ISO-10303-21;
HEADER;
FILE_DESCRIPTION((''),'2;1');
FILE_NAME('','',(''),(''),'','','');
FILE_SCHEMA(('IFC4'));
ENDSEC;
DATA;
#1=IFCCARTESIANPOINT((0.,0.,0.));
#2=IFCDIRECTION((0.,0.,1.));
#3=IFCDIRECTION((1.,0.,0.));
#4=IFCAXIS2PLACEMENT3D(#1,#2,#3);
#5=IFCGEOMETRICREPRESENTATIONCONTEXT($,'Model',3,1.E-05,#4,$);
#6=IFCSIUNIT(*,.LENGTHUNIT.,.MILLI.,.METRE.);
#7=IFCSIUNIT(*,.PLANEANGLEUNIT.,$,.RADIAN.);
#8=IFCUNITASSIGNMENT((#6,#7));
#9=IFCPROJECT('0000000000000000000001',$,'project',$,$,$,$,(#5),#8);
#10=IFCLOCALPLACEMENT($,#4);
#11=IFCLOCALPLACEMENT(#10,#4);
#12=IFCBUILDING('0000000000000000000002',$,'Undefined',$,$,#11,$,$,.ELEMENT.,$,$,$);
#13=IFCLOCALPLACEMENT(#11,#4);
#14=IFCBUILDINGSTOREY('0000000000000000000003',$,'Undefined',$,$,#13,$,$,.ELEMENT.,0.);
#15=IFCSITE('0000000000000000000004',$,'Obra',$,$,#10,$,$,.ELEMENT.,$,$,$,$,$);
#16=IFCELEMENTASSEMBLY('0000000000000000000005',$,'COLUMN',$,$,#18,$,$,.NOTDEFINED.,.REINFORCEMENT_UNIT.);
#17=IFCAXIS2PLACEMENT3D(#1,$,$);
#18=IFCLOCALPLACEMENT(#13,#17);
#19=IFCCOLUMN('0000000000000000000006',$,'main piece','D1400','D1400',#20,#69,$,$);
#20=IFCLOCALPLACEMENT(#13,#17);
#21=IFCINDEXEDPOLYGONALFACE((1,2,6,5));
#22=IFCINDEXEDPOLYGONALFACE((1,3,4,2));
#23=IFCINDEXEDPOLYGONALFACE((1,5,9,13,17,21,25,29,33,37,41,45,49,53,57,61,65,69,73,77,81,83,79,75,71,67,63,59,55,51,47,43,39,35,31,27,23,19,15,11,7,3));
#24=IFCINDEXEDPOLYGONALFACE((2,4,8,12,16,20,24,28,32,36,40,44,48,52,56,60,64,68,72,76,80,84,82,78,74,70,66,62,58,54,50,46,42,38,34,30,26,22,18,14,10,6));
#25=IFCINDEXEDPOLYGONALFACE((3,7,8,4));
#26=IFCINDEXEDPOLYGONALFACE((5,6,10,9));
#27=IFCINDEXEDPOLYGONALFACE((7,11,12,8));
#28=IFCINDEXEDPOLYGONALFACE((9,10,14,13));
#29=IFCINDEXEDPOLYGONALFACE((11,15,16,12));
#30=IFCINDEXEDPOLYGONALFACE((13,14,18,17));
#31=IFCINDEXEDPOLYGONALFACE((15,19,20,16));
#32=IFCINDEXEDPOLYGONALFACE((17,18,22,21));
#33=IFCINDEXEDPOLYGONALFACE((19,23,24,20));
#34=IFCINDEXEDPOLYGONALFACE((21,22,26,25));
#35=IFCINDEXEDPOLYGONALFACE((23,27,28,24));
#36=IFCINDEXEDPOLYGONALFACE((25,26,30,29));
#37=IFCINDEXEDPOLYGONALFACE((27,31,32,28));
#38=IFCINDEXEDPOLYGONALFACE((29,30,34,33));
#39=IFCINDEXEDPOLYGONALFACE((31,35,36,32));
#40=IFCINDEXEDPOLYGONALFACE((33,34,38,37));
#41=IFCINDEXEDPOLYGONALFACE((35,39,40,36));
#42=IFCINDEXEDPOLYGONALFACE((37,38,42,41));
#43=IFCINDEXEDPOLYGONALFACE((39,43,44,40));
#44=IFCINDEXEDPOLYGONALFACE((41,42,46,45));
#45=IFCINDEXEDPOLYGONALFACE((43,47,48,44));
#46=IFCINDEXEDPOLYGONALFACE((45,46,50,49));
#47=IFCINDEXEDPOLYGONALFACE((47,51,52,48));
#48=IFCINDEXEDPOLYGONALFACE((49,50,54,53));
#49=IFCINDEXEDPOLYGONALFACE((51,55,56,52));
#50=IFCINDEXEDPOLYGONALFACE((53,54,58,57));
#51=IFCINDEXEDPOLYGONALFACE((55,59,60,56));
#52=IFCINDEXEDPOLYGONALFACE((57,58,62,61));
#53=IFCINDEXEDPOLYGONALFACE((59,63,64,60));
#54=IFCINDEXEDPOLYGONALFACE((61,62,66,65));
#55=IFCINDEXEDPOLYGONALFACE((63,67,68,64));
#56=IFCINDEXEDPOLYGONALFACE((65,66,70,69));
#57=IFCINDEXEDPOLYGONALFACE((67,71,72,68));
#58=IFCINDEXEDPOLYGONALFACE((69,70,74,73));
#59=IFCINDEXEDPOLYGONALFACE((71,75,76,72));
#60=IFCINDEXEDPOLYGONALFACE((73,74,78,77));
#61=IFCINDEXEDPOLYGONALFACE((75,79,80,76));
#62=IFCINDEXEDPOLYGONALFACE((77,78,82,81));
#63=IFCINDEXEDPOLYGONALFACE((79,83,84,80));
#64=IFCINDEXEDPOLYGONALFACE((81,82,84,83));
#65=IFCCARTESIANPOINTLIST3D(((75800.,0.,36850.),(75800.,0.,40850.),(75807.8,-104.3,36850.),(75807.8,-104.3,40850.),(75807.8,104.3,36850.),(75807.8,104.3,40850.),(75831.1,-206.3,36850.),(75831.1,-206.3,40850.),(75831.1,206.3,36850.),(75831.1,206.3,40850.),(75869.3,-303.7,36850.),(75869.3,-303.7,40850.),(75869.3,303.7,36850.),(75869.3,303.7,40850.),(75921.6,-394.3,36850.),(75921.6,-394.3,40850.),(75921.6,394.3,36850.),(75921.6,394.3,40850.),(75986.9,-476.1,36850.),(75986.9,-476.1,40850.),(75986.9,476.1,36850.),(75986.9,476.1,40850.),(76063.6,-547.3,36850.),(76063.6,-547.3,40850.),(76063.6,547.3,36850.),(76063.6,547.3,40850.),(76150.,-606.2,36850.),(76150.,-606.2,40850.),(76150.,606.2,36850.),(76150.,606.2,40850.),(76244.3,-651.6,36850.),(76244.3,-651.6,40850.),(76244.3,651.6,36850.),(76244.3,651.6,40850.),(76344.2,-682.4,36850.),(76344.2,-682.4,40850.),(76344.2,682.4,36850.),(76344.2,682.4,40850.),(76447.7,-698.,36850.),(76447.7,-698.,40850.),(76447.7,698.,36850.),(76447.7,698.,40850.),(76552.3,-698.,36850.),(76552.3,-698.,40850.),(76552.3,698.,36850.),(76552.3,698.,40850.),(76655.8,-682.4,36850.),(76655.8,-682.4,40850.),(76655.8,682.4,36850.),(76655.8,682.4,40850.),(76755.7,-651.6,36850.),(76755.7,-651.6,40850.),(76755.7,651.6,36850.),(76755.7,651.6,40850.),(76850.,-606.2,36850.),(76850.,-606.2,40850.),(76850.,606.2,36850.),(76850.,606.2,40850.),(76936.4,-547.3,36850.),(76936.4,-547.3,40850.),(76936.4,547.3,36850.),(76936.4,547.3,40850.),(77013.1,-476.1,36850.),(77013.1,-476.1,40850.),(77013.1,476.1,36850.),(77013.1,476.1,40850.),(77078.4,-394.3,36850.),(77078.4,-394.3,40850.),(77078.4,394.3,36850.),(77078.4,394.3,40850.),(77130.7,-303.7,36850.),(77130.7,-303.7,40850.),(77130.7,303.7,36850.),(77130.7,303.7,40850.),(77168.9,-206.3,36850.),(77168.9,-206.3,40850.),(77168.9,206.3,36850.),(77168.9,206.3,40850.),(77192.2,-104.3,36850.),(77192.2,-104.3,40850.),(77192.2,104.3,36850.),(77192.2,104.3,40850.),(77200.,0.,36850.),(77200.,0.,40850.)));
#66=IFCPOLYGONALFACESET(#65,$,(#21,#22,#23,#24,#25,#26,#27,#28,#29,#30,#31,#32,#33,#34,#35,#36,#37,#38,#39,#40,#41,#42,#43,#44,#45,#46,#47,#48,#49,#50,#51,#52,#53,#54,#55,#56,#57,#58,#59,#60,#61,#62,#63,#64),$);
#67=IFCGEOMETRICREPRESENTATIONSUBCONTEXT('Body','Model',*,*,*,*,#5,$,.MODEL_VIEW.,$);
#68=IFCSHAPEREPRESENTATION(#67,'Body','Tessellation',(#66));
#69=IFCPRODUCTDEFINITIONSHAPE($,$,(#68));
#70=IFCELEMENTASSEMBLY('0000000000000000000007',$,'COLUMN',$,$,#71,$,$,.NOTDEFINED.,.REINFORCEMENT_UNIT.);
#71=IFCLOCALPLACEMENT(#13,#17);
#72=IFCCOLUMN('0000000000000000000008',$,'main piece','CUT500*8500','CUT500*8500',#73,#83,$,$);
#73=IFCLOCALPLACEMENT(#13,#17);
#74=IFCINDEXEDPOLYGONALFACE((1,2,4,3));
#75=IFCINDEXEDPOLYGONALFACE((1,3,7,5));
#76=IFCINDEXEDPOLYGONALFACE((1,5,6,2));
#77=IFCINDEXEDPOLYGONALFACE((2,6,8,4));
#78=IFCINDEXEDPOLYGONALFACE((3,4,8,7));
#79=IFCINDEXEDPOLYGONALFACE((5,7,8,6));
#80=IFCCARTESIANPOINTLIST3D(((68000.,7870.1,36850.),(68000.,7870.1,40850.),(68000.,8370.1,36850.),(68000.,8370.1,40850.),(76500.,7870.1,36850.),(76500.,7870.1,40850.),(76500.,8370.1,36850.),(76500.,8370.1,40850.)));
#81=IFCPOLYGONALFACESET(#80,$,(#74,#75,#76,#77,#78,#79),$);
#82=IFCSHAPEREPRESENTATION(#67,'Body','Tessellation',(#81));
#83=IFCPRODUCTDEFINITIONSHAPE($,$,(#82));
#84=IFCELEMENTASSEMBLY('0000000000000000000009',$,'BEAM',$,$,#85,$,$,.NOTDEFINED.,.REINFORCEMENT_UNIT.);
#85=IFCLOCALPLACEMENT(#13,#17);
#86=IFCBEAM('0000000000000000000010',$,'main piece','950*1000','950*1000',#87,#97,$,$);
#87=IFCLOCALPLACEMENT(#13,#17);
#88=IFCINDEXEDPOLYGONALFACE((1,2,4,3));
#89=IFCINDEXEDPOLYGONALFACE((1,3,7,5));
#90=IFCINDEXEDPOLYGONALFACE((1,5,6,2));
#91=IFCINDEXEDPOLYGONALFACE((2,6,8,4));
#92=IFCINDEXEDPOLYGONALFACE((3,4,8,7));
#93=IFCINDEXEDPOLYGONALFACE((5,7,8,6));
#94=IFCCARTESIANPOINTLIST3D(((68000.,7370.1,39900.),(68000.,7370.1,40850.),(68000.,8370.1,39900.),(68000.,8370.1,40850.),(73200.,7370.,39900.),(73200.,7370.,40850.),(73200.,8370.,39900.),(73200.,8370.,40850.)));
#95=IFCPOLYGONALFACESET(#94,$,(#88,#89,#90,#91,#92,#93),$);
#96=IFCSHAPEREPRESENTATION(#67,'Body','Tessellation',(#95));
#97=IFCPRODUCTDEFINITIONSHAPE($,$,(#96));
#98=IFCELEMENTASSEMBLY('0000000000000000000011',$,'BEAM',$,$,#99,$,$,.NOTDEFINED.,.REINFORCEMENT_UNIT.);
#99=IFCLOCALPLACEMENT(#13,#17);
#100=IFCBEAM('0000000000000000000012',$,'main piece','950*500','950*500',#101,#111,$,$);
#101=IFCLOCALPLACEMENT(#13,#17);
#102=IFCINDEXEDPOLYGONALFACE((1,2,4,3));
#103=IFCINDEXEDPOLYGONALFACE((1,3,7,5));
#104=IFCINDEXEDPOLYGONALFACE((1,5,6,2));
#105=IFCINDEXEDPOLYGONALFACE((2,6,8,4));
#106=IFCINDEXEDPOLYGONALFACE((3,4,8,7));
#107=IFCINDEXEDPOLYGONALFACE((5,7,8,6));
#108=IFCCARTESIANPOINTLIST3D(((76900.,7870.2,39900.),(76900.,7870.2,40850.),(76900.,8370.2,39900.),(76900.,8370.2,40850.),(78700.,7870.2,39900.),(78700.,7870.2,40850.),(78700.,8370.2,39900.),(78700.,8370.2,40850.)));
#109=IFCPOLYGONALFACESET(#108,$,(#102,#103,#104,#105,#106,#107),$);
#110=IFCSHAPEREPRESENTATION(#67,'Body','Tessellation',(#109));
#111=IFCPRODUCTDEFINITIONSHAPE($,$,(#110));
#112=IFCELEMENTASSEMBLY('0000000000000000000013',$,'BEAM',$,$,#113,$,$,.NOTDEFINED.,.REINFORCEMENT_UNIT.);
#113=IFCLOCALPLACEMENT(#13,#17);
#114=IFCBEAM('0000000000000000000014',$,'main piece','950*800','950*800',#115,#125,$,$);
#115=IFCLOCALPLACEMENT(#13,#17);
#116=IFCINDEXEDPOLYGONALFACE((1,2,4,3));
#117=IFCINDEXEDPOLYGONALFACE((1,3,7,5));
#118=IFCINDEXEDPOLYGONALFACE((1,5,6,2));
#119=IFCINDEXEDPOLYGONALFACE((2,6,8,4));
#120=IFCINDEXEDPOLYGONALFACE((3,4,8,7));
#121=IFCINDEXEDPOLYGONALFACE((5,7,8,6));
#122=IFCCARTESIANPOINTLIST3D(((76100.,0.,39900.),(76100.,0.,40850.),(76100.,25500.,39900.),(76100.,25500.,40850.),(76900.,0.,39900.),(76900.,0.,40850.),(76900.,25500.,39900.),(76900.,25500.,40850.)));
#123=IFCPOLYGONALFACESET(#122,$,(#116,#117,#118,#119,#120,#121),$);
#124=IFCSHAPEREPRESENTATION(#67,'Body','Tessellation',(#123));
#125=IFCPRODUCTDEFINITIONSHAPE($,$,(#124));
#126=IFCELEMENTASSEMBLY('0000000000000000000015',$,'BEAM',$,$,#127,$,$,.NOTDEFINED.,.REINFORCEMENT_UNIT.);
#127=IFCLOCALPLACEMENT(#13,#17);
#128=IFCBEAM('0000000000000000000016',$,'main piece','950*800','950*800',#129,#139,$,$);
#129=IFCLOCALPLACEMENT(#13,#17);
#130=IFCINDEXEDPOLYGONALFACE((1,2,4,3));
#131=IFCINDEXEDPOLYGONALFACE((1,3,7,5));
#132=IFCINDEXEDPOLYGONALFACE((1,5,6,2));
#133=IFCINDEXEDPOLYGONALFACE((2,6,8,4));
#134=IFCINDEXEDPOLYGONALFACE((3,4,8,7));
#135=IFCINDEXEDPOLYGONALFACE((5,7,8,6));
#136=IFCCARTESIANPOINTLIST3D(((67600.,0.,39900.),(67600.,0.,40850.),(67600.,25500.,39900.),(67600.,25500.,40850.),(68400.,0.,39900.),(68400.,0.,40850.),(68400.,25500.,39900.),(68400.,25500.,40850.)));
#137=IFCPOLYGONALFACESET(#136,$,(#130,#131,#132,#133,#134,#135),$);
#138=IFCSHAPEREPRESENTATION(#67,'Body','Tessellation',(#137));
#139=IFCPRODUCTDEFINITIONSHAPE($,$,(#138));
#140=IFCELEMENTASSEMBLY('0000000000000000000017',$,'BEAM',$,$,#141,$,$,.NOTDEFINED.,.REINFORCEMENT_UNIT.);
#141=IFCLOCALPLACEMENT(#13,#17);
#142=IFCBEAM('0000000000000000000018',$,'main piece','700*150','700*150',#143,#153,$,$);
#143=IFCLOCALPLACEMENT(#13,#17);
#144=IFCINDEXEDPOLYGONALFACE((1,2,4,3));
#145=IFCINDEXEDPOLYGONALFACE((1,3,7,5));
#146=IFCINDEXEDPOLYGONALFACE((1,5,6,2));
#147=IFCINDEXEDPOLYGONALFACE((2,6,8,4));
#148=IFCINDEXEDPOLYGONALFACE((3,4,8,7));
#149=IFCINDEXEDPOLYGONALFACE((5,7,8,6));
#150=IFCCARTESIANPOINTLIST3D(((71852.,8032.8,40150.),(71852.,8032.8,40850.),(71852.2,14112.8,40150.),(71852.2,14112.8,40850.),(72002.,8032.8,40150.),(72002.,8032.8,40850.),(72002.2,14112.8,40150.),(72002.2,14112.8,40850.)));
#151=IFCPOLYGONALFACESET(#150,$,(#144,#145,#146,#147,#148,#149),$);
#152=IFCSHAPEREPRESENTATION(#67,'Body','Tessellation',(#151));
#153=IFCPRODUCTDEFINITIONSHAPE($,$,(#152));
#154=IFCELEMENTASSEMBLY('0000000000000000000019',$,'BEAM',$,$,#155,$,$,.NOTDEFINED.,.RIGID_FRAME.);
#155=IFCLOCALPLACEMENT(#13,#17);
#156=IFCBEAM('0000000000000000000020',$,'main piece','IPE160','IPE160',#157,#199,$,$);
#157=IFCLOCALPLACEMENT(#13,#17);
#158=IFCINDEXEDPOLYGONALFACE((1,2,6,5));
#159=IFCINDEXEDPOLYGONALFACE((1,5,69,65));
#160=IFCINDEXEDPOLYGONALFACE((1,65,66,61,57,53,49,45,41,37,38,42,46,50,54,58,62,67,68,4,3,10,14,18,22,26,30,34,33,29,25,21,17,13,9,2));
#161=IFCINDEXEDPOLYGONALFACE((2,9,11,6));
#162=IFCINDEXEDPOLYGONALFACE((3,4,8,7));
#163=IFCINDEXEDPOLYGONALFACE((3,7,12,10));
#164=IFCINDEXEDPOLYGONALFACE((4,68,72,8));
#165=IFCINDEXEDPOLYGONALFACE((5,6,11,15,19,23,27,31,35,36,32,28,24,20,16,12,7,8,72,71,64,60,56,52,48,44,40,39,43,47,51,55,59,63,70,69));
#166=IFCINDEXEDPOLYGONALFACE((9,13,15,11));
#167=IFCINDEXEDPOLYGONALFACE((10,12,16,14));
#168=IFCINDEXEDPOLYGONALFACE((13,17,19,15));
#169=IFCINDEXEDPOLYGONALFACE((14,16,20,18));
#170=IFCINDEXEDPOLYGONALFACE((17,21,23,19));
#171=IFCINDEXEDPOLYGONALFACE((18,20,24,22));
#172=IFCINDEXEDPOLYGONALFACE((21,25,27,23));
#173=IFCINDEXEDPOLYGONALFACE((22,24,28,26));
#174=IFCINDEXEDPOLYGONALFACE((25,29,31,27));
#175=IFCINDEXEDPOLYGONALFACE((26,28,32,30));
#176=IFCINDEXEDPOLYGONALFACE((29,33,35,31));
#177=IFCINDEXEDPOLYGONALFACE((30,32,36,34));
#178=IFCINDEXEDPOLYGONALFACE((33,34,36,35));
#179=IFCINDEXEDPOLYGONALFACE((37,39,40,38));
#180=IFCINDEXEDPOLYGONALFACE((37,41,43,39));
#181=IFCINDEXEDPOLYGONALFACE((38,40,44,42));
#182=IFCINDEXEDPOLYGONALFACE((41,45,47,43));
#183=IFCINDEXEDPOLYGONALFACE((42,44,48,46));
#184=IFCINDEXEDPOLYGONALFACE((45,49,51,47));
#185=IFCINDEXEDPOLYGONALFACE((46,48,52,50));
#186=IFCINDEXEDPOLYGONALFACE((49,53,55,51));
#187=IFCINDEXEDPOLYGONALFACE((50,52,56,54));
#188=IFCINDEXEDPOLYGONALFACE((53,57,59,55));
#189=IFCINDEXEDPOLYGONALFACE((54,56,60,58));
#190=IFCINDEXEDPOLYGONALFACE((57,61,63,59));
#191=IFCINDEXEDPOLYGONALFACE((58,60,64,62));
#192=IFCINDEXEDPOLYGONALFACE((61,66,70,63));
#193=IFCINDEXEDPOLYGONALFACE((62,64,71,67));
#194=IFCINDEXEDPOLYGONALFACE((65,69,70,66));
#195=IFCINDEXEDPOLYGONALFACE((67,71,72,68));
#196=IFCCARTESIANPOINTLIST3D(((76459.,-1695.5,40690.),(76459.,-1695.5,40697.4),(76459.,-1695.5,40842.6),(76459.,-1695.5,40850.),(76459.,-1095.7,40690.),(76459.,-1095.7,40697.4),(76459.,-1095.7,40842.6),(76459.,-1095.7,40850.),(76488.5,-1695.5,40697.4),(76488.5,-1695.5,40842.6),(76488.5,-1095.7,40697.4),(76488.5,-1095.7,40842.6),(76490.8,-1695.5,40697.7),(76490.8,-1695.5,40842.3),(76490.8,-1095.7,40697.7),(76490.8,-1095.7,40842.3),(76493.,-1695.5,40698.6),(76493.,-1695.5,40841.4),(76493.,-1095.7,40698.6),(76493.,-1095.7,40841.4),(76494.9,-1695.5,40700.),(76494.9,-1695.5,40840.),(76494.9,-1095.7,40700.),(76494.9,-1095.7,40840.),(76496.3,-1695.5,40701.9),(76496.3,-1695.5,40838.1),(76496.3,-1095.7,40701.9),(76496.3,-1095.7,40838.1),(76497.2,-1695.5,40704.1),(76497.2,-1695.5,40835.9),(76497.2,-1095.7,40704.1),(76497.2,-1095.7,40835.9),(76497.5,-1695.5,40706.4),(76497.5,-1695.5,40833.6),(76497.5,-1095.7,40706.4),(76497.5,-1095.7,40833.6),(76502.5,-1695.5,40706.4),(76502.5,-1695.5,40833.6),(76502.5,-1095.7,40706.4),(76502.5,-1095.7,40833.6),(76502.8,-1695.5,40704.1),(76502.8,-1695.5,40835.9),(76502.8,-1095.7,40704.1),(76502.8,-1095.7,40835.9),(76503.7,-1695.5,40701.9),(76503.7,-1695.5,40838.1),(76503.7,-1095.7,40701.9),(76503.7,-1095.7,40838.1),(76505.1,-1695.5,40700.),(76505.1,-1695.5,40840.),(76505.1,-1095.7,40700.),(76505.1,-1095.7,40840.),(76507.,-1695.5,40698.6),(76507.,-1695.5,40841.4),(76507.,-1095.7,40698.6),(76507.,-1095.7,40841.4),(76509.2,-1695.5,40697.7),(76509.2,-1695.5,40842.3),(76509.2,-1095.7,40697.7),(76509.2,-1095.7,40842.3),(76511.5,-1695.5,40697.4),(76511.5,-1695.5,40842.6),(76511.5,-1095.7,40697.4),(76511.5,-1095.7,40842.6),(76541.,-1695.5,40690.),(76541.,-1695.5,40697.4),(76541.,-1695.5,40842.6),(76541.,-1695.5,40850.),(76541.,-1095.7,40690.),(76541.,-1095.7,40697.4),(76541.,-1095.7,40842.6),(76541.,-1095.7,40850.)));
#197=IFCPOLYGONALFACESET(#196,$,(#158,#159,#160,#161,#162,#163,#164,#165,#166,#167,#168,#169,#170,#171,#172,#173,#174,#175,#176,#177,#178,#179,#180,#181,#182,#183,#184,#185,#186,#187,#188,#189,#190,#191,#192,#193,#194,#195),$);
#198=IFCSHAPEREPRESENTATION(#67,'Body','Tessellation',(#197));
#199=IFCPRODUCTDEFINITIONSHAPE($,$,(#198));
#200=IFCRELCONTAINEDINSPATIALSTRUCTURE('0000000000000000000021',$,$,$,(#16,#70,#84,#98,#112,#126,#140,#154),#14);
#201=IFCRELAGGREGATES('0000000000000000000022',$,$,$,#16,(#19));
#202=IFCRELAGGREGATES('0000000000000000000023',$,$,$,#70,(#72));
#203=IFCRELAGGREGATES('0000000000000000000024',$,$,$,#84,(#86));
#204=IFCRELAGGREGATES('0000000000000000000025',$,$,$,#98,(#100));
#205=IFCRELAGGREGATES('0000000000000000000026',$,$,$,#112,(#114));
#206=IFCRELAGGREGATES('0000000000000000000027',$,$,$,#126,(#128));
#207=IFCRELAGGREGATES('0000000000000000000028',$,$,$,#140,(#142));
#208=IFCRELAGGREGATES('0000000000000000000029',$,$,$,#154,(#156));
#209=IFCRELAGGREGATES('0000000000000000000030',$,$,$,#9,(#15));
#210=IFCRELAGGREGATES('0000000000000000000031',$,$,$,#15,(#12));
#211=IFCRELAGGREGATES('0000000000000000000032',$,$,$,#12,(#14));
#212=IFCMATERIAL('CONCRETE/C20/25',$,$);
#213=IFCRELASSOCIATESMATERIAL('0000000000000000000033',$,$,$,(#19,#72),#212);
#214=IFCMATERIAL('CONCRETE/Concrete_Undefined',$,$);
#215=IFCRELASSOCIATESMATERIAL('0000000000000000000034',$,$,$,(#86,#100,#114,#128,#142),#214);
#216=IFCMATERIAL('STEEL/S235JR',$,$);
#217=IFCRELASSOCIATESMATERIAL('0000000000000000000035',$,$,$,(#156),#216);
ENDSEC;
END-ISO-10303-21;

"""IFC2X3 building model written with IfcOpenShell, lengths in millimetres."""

from ifc_helpers import new_model, si_unit, frame, origin_with_axes, origin_2d_with_axis, place, context, subcontext, project, spatial, rectangle, circle, i_section, extrude, material, element, aggregate, save


model = new_model("IFC2X3")

# Units and contexts
model_context = context("Model", 3, precision=1e-05, world=origin_with_axes())
body_context = subcontext(model_context, "Body", "Model", "MODEL_VIEW")
ifc_project = project(units=[si_unit("LENGTHUNIT", "METRE", prefix="MILLI"), si_unit("PLANEANGLEUNIT", "RADIAN")], contexts=[model_context])

# Site, building, storey
site_placement = place(None, origin_with_axes())
site = spatial("IfcSite", under=ifc_project, at=site_placement, Name="Obra", CompositionType="ELEMENT")
building_placement = place(site_placement, origin_with_axes())
building = spatial("IfcBuilding", under=site, at=building_placement, Name="Undefined", CompositionType="ELEMENT")
storey_placement = place(building_placement, origin_with_axes())
storey = spatial("IfcBuildingStorey", under=building, at=storey_placement, Name="Undefined", CompositionType="ELEMENT", Elevation=0.0)

# Element assemblies, columns
ifc_material_1 = material(Name="CONCRETE/C20/25")
assembly_1_placement = place(storey_placement, origin_with_axes())
assembly_1 = element("IfcElementAssembly", 1, at=assembly_1_placement, inside=storey, Name="COLUMN", AssemblyPlace="NOTDEFINED", PredefinedType="REINFORCEMENT_UNIT")
column_1_placement = place(assembly_1_placement, frame((76500.0, 0.0, 36850.0), z_axis=(0.0, 0.0, 1.0), x_axis=(0.0, 1.0, 0.0)))
column_1 = element("IfcColumn", 2, at=column_1_placement, material=ifc_material_1, Name="main piece", Description="D1400", ObjectType="D1400", context=body_context, shape_type="SweptSolid", body=[
    extrude(circle(Radius=700.0, at=origin_2d_with_axis()), frame((0.0, 0.0, 4000.0), z_axis=(0.0, 0.0, -1.0), x_axis=(0.0, 1.0, 0.0)), (0.0, 0.0, 1.0), 4000.0),
])
aggregate(assembly_1, [column_1])
assembly_2_placement = place(storey_placement, origin_with_axes())
assembly_2 = element("IfcElementAssembly", 3, at=assembly_2_placement, inside=storey, Name="COLUMN", AssemblyPlace="NOTDEFINED", PredefinedType="REINFORCEMENT_UNIT")
column_2_placement = place(assembly_2_placement, frame((72250.0, 8120.1, 36850.0), z_axis=(0.0, 0.0, 1.0), x_axis=(-1.0, 0.0, 0.0)))
column_2 = element("IfcColumn", 4, at=column_2_placement, material=ifc_material_1, Name="main piece", Description="CUT500*8500", ObjectType="CUT500*8500", context=body_context, shape_type="SweptSolid", body=[
    extrude(rectangle(XDim=500.0, YDim=8500.0, at=origin_2d_with_axis()), frame((0.0, 0.0, 4000.0), z_axis=(0.0, 0.0, -1.0), x_axis=(0.0, 1.0, 0.0)), (0.0, 0.0, 1.0), 4000.0),
])
aggregate(assembly_2, [column_2])

# Element assemblies, beams
assembly_3_placement = place(storey_placement, origin_with_axes())
assembly_3 = element("IfcElementAssembly", 5, at=assembly_3_placement, inside=storey, Name="BEAM", AssemblyPlace="NOTDEFINED", PredefinedType="REINFORCEMENT_UNIT")
ifc_material_2 = material(Name="CONCRETE/Concrete_Undefined")
beam_1_placement = place(assembly_3_placement, frame((68000.0, 7870.1, 40375.0), z_axis=(0.0, 0.0, 1.0), x_axis=(1.0, -0.000019, 0.0)))
beam_1 = element("IfcBeam", 6, at=beam_1_placement, material=ifc_material_2, Name="main piece", Description="950*1000", ObjectType="950*1000", context=body_context, shape_type="SweptSolid", body=[
    extrude(rectangle(XDim=1000.0, YDim=950.0, at=origin_2d_with_axis()), frame((5200.0, 0.0, 0.0), z_axis=(-1.0, 0.0, 0.0), x_axis=(0.0, -1.0, 0.0)), (0.0, 0.0, 1.0), 5200.0),
])
aggregate(assembly_3, [beam_1])
assembly_4_placement = place(storey_placement, origin_with_axes())
assembly_4 = element("IfcElementAssembly", 7, at=assembly_4_placement, inside=storey, Name="BEAM", AssemblyPlace="NOTDEFINED", PredefinedType="REINFORCEMENT_UNIT")
beam_2_placement = place(assembly_4_placement, frame((78700.0, 8120.2, 40375.0), z_axis=(0.0, 0.0, 1.0), x_axis=(-1.0, 0.0, 0.0)))
beam_2 = element("IfcBeam", 8, at=beam_2_placement, material=ifc_material_2, Name="main piece", Description="950*500", ObjectType="950*500", context=body_context, shape_type="SweptSolid", body=[
    extrude(rectangle(XDim=500.0, YDim=950.0, at=origin_2d_with_axis()), frame((1800.0, 0.0, 0.0), z_axis=(-1.0, 0.0, 0.0), x_axis=(0.0, -1.0, 0.0)), (0.0, 0.0, 1.0), 1800.0),
])
aggregate(assembly_4, [beam_2])
assembly_5_placement = place(storey_placement, origin_with_axes())
assembly_5 = element("IfcElementAssembly", 9, at=assembly_5_placement, inside=storey, Name="BEAM", AssemblyPlace="NOTDEFINED", PredefinedType="REINFORCEMENT_UNIT")
beam_3_placement = place(assembly_5_placement, frame((76500.0, 0.0, 40375.0), z_axis=(0.0, 0.0, 1.0), x_axis=(0.0, 1.0, 0.0)))
beam_3 = element("IfcBeam", 10, at=beam_3_placement, material=ifc_material_2, Name="main piece", Description="950*800", ObjectType="950*800", context=body_context, shape_type="SweptSolid", body=[
    extrude(rectangle(XDim=800.0, YDim=950.0, at=origin_2d_with_axis()), frame((25500.0, 0.0, 0.0), z_axis=(-1.0, 0.0, 0.0), x_axis=(0.0, -1.0, 0.0)), (0.0, 0.0, 1.0), 25500.0),
])
aggregate(assembly_5, [beam_3])
assembly_6_placement = place(storey_placement, origin_with_axes())
assembly_6 = element("IfcElementAssembly", 11, at=assembly_6_placement, inside=storey, Name="BEAM", AssemblyPlace="NOTDEFINED", PredefinedType="REINFORCEMENT_UNIT")
beam_4_placement = place(assembly_6_placement, frame((68000.0, 0.0, 40375.0), z_axis=(0.0, 0.0, 1.0), x_axis=(0.0, 1.0, 0.0)))
beam_4 = element("IfcBeam", 12, at=beam_4_placement, material=ifc_material_2, Name="main piece", Description="950*800", ObjectType="950*800", context=body_context, shape_type="SweptSolid", body=[
    extrude(rectangle(XDim=800.0, YDim=950.0, at=origin_2d_with_axis()), frame((25500.0, 0.0, 0.0), z_axis=(-1.0, 0.0, 0.0), x_axis=(0.0, -1.0, 0.0)), (0.0, 0.0, 1.0), 25500.0),
])
aggregate(assembly_6, [beam_4])
assembly_7_placement = place(storey_placement, origin_with_axes())
assembly_7 = element("IfcElementAssembly", 13, at=assembly_7_placement, inside=storey, Name="BEAM", AssemblyPlace="NOTDEFINED", PredefinedType="REINFORCEMENT_UNIT")
beam_5_placement = place(assembly_7_placement, frame((71927.0, 8032.8, 40500.0), z_axis=(0.0, 0.0, 1.0), x_axis=(0.000033, 1.0, 0.0)))
beam_5 = element("IfcBeam", 14, at=beam_5_placement, material=ifc_material_2, Name="main piece", Description="700*150", ObjectType="700*150", context=body_context, shape_type="SweptSolid", body=[
    extrude(rectangle(XDim=150.0, YDim=700.0, at=origin_2d_with_axis()), frame((6080.0, 0.0, 0.0), z_axis=(-1.0, 0.0, 0.0), x_axis=(0.0, -1.0, 0.0)), (0.0, 0.0, 1.0), 6080.0),
])
aggregate(assembly_7, [beam_5])
assembly_8_placement = place(storey_placement, origin_with_axes())
assembly_8 = element("IfcElementAssembly", 15, at=assembly_8_placement, inside=storey, Name="BEAM", AssemblyPlace="NOTDEFINED", PredefinedType="RIGID_FRAME")
ifc_material_3 = material(Name="STEEL/S235JR")
beam_6_placement = place(assembly_8_placement, frame((76500.0, -1095.7, 40770.0), z_axis=(0.0, 0.0, 1.0), x_axis=(0.0, -1.0, 0.0)))
beam_6 = element("IfcBeam", 16, at=beam_6_placement, material=ifc_material_3, Name="main piece", Description="IPE160", ObjectType="IPE160", context=body_context, shape_type="SweptSolid", body=[
    extrude(i_section(OverallWidth=82.0, OverallDepth=160.0, WebThickness=5.0, FlangeThickness=7.4, FilletRadius=9.0, at=origin_2d_with_axis()), frame((599.8, 0.0, 0.0), z_axis=(-1.0, 0.0, 0.0), x_axis=(0.0, -1.0, 0.0)), (0.0, 0.0, 1.0), 599.8),
])
aggregate(assembly_8, [beam_6])

save(model, "model.ifc")
